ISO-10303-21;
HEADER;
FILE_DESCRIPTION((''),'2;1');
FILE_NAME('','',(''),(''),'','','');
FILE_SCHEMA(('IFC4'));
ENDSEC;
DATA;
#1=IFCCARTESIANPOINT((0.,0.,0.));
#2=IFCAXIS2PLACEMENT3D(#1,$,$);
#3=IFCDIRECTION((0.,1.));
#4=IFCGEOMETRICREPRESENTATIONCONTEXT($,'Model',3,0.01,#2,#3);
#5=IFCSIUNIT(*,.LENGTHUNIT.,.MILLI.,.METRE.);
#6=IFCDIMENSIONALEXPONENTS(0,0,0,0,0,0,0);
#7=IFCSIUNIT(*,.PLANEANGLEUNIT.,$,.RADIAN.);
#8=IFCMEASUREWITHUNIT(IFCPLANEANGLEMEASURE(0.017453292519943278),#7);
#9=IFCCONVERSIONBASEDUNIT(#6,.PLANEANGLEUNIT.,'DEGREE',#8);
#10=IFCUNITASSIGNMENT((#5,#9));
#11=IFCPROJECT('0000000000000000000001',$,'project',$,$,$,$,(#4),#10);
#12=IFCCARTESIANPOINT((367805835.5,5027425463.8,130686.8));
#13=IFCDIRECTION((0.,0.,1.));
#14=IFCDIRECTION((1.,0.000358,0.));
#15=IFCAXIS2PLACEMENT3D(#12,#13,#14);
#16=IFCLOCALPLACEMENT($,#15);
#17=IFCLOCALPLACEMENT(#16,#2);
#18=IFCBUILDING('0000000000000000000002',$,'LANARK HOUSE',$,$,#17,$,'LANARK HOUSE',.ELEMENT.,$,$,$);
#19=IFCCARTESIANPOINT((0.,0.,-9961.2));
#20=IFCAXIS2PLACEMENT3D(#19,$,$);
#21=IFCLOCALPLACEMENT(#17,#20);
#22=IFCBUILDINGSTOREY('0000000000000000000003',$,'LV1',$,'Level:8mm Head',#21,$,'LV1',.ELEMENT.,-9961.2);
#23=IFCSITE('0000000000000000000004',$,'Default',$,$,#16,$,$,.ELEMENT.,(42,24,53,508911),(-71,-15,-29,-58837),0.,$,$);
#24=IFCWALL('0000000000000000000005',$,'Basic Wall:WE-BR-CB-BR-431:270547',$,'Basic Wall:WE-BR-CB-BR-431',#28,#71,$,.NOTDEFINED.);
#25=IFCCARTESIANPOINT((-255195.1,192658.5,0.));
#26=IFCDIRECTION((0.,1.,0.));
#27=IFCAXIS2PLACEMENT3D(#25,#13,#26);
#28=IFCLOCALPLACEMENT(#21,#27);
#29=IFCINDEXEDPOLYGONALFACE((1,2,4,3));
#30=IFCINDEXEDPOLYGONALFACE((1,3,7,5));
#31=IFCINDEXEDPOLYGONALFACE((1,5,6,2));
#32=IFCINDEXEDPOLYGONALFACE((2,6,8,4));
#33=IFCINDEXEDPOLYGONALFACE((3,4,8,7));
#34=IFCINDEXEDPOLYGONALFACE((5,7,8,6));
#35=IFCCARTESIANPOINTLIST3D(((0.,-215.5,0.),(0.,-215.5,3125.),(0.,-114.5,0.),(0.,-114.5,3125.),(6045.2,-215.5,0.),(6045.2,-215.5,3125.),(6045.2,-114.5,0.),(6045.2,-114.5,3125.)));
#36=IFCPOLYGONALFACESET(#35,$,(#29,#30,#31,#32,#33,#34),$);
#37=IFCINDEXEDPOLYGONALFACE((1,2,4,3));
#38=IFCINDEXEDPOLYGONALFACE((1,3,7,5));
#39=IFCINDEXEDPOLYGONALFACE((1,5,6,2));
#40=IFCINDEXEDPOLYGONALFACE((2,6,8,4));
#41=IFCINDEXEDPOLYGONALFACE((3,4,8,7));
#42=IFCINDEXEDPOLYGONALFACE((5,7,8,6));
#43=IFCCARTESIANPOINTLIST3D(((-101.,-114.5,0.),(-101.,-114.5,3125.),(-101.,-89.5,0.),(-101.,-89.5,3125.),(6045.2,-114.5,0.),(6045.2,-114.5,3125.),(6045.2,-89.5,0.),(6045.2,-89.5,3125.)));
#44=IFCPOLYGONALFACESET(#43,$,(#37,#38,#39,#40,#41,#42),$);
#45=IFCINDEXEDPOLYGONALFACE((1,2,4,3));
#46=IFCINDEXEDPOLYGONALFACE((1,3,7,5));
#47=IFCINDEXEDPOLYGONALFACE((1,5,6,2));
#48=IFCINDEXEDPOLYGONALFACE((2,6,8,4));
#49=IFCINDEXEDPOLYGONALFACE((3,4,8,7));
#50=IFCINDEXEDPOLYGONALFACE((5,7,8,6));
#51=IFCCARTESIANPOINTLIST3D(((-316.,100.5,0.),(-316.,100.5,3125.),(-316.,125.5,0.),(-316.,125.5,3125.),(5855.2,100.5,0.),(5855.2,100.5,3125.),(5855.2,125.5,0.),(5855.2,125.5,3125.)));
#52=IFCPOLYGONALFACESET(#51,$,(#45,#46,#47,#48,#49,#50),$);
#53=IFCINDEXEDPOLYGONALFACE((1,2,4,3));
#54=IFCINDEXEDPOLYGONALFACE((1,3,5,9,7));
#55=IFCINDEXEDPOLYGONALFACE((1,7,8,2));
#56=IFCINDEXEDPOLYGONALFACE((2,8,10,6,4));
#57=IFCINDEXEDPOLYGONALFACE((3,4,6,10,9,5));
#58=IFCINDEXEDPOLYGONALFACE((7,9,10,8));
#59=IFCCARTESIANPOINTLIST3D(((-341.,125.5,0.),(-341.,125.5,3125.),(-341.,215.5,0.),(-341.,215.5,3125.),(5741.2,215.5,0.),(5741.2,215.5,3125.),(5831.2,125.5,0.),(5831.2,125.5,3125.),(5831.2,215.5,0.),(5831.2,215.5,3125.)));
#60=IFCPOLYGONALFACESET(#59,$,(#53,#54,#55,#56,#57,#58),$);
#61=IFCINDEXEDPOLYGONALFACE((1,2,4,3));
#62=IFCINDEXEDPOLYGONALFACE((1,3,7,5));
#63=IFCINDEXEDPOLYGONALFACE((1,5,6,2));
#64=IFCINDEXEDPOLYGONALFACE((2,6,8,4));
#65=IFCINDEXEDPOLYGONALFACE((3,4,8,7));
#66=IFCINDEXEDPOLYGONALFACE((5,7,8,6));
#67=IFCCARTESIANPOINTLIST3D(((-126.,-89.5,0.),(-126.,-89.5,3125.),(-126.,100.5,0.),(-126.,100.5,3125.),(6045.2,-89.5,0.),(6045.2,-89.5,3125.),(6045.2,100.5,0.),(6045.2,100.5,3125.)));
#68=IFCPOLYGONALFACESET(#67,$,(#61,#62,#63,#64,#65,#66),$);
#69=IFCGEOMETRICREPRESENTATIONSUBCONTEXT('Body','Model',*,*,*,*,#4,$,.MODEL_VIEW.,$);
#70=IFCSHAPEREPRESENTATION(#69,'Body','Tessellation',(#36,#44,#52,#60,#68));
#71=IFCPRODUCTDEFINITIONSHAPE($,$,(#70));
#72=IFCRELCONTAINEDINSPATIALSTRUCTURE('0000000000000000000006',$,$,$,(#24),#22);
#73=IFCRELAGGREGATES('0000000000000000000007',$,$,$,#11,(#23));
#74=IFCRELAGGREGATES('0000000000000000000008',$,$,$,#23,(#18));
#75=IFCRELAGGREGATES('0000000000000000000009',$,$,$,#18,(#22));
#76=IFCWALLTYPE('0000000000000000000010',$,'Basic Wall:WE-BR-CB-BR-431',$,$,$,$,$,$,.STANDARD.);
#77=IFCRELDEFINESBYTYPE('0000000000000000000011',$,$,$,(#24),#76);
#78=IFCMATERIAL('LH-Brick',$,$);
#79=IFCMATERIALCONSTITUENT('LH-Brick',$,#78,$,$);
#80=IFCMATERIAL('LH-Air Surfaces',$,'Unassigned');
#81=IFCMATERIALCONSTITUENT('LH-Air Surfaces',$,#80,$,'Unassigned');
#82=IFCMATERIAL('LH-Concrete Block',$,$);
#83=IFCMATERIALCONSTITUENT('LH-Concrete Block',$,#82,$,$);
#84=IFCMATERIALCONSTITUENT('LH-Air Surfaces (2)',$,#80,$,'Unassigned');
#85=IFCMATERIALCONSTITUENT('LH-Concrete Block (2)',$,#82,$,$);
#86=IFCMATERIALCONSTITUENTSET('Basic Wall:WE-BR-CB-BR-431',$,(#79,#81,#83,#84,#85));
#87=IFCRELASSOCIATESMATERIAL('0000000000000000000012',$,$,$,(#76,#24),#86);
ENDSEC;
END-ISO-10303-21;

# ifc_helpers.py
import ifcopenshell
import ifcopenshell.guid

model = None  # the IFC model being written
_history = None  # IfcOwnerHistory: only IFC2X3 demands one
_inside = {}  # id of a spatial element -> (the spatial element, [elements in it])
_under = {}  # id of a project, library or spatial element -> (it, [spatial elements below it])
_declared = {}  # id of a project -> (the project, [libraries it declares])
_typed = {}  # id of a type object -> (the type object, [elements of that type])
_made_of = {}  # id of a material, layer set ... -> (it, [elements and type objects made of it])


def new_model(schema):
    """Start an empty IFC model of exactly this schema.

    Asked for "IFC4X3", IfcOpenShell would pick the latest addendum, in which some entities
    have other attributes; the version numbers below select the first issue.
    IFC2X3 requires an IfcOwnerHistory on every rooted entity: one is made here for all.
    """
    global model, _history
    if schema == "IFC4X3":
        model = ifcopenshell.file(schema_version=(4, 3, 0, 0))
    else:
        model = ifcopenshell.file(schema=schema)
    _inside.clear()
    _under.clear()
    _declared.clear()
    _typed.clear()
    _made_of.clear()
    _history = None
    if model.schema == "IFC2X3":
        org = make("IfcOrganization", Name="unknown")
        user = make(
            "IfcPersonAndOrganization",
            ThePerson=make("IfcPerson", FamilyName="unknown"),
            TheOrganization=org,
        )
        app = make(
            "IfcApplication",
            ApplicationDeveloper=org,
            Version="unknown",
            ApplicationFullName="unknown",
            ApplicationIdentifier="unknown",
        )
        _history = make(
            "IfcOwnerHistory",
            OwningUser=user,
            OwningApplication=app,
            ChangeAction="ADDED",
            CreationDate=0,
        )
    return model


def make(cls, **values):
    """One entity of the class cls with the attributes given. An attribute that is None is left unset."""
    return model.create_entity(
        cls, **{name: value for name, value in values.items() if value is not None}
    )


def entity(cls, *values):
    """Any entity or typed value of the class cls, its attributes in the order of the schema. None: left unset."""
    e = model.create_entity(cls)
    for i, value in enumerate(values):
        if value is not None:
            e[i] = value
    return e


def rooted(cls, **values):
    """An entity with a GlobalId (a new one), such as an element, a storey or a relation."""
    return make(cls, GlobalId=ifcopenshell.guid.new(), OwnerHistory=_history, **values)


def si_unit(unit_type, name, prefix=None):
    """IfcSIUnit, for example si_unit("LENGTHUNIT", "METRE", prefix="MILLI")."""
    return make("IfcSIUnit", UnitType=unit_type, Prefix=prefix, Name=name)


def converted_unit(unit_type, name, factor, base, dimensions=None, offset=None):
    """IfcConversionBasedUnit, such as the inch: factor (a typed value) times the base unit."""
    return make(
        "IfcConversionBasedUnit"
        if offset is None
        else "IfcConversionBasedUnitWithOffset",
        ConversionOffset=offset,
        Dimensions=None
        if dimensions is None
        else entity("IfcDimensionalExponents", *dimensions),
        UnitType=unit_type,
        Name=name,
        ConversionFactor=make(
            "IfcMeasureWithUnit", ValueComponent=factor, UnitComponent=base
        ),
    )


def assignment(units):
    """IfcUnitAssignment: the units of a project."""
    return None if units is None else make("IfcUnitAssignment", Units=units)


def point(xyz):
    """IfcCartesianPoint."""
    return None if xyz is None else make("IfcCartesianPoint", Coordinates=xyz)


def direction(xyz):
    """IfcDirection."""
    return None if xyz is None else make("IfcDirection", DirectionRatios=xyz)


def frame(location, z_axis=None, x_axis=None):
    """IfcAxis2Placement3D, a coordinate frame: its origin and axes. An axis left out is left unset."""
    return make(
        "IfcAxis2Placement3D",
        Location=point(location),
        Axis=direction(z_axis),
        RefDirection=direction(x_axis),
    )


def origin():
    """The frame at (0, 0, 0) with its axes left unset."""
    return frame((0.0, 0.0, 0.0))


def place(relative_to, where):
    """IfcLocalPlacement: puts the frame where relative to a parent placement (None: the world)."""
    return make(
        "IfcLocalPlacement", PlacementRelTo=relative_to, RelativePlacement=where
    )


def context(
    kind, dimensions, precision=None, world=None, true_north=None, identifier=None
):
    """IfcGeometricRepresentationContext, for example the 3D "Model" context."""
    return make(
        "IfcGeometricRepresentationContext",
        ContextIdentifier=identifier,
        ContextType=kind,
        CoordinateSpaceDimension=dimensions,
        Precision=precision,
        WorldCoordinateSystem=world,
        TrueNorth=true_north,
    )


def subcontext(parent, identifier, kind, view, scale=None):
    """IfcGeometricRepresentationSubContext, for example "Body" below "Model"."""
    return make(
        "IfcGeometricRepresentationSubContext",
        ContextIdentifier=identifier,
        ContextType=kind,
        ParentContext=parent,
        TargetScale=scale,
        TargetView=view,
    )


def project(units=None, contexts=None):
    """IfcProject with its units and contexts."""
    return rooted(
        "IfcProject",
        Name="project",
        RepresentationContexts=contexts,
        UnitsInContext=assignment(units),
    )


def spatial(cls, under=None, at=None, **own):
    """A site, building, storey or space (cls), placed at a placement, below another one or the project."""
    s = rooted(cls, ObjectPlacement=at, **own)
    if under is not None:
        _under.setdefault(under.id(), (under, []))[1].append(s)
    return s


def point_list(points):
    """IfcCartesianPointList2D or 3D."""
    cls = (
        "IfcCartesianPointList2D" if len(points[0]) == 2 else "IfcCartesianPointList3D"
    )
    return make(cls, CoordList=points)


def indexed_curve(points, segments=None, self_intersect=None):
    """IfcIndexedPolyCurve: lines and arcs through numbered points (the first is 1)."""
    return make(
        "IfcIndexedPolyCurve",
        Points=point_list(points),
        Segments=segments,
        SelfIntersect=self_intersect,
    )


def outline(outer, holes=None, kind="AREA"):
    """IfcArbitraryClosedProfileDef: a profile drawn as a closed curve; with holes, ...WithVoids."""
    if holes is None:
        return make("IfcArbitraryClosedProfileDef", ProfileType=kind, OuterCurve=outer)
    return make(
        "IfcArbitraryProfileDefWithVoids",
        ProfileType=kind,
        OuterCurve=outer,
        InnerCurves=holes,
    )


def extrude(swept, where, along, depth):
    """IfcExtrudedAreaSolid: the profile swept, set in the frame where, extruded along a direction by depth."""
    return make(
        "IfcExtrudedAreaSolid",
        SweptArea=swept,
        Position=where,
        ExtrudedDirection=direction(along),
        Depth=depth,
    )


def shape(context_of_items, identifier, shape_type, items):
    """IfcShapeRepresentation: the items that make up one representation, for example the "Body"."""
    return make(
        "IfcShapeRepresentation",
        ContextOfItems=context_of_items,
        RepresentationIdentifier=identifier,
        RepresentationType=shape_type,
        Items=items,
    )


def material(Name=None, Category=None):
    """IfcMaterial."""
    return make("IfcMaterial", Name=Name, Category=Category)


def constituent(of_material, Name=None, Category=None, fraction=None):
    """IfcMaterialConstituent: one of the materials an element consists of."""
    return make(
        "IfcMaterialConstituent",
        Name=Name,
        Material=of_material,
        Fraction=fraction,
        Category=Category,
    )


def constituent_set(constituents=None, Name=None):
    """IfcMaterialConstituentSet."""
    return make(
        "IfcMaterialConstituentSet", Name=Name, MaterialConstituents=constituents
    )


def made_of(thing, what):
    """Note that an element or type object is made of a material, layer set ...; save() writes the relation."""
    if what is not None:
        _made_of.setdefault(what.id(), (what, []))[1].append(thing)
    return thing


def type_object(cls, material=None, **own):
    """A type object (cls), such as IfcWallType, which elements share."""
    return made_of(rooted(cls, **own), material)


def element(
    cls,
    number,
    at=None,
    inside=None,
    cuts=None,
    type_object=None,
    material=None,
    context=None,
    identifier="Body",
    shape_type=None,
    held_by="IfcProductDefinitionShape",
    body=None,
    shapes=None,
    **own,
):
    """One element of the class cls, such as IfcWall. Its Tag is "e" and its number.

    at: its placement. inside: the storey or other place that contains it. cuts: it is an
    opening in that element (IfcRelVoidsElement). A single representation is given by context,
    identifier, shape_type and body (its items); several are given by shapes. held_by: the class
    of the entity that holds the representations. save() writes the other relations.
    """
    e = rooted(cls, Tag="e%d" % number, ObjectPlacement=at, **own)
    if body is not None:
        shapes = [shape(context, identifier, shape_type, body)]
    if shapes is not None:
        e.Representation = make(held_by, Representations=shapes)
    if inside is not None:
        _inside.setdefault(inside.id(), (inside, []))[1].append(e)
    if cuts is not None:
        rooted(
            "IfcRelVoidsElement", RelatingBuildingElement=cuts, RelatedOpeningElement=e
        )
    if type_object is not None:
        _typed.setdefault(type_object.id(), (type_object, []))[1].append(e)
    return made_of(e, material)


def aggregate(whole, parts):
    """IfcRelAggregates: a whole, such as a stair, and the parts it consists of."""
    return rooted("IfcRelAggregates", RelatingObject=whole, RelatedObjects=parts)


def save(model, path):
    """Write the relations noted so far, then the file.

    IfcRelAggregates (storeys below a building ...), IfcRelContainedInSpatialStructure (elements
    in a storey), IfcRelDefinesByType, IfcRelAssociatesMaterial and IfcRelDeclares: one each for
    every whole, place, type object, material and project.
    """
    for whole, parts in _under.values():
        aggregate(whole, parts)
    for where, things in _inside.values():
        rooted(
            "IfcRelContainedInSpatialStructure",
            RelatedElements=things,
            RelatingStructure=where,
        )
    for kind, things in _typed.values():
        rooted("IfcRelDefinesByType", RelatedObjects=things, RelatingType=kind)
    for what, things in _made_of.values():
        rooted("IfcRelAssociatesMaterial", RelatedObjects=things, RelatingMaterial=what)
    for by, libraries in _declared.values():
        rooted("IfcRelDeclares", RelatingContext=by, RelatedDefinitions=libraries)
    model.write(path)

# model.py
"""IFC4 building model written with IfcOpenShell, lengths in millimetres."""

from ifc_helpers import new_model, entity, si_unit, converted_unit, direction, frame, origin, place, context, subcontext, project, spatial, indexed_curve, outline, extrude, material, constituent, constituent_set, type_object, element, save


model = new_model("IFC4")

# Units and contexts
model_context = context("Model", 3, precision=0.01, world=origin(), true_north=direction((0.0, 1.0)))
body_context = subcontext(model_context, "Body", "Model", "MODEL_VIEW")
ifc_project = project(units=[si_unit("LENGTHUNIT", "METRE", prefix="MILLI"), converted_unit("PLANEANGLEUNIT", "DEGREE", entity("IfcPlaneAngleMeasure", 0.017453292519943278), si_unit("PLANEANGLEUNIT", "RADIAN"), dimensions=[0, 0, 0, 0, 0, 0, 0])], contexts=[model_context])

# Site, building, storey
site_placement = place(None, frame((367805835.5, 5027425463.8, 130686.8), z_axis=(0.0, 0.0, 1.0), x_axis=(1.0, 0.000358, 0.0)))
site = spatial("IfcSite", under=ifc_project, at=site_placement, Name="Default", CompositionType="ELEMENT", RefLatitude=(42, 24, 53, 508911), RefLongitude=(-71, -15, -29, -58837), RefElevation=0.0)
building_placement = place(site_placement, origin())
building = spatial("IfcBuilding", under=site, at=building_placement, Name="LANARK HOUSE", LongName="LANARK HOUSE", CompositionType="ELEMENT")
storey_placement = place(building_placement, frame((0.0, 0.0, -9961.2)))
storey = spatial("IfcBuildingStorey", under=building, at=storey_placement, Name="LV1", ObjectType="Level:8mm Head", LongName="LV1", CompositionType="ELEMENT", Elevation=-9961.2)

# Wall
ifc_material_1 = material(Name="LH-Brick")
ifc_constituent_1 = constituent(ifc_material_1, Name="LH-Brick")
ifc_material_2 = material(Name="LH-Air Surfaces", Category="Unassigned")
ifc_constituent_2 = constituent(ifc_material_2, Name="LH-Air Surfaces", Category="Unassigned")
ifc_material_3 = material(Name="LH-Concrete Block")
ifc_constituent_3 = constituent(ifc_material_3, Name="LH-Concrete Block")
ifc_constituent_4 = constituent(ifc_material_2, Name="LH-Air Surfaces (2)", Category="Unassigned")
ifc_constituent_5 = constituent(ifc_material_3, Name="LH-Concrete Block (2)")
ifc_constituent_set_1 = constituent_set(constituents=[ifc_constituent_1, ifc_constituent_2, ifc_constituent_3, ifc_constituent_4, ifc_constituent_5], Name="Basic Wall:WE-BR-CB-BR-431")
wall_type_1 = type_object("IfcWallType", Name="Basic Wall:WE-BR-CB-BR-431", PredefinedType="STANDARD", material=ifc_constituent_set_1)
wall_1_placement = place(storey_placement, frame((-255195.1, 192658.5, 0.0), z_axis=(0.0, 0.0, 1.0), x_axis=(0.0, 1.0, 0.0)))
element("IfcWall", 1, at=wall_1_placement, inside=storey, type_object=wall_type_1, material=ifc_constituent_set_1, Name="Basic Wall:WE-BR-CB-BR-431:270547", ObjectType="Basic Wall:WE-BR-CB-BR-431", PredefinedType="NOTDEFINED", context=body_context, shape_type="SweptSolid", body=[
    extrude(outline(indexed_curve([(-50.5, -3022.6), (50.5, -3022.6), (50.5, 3022.6), (-50.5, 3022.6), (-50.5, -3022.6)], self_intersect=False)), frame((3022.6, -165.0, 0.0), z_axis=(0.0, 0.0, 1.0), x_axis=(0.0, 1.0, 0.0)), (0.0, 0.0, 1.0), 3125.0),
    extrude(outline(indexed_curve([(-3073.1, -12.5), (3073.1, -12.5), (3073.1, 12.5), (-3073.1, 12.5), (-3073.1, -12.5)], self_intersect=False)), frame((2972.1, -102.0, 0.0)), (0.0, 0.0, 1.0), 3125.0),
    extrude(outline(indexed_curve([(-3085.6, -12.5), (3085.6, -12.5), (3085.6, 12.5), (-3085.6, 12.5), (-3085.6, -12.5)], self_intersect=False)), frame((2769.6, 113.0, 0.0)), (0.0, 0.0, 1.0), 3125.0),
    extrude(outline(indexed_curve([(-2396.9, -36.0), (3685.3, -36.0), (3685.3, 54.0), (-2486.9, 54.0), (-2486.9, -36.0), (-2396.9, -36.0)], self_intersect=False)), frame((3344.3, 179.5, 0.0), z_axis=(0.0, 0.0, 1.0), x_axis=(-1.0, 0.0, 0.0)), (0.0, 0.0, 1.0), 3125.0),
    extrude(outline(indexed_curve([(-3085.6, -95.0), (3085.6, -95.0), (3085.6, 95.0), (-3085.6, 95.0), (-3085.6, -95.0)], self_intersect=False)), frame((2959.6, 5.5, 0.0)), (0.0, 0.0, 1.0), 3125.0),
])

save(model, "model.ifc")
